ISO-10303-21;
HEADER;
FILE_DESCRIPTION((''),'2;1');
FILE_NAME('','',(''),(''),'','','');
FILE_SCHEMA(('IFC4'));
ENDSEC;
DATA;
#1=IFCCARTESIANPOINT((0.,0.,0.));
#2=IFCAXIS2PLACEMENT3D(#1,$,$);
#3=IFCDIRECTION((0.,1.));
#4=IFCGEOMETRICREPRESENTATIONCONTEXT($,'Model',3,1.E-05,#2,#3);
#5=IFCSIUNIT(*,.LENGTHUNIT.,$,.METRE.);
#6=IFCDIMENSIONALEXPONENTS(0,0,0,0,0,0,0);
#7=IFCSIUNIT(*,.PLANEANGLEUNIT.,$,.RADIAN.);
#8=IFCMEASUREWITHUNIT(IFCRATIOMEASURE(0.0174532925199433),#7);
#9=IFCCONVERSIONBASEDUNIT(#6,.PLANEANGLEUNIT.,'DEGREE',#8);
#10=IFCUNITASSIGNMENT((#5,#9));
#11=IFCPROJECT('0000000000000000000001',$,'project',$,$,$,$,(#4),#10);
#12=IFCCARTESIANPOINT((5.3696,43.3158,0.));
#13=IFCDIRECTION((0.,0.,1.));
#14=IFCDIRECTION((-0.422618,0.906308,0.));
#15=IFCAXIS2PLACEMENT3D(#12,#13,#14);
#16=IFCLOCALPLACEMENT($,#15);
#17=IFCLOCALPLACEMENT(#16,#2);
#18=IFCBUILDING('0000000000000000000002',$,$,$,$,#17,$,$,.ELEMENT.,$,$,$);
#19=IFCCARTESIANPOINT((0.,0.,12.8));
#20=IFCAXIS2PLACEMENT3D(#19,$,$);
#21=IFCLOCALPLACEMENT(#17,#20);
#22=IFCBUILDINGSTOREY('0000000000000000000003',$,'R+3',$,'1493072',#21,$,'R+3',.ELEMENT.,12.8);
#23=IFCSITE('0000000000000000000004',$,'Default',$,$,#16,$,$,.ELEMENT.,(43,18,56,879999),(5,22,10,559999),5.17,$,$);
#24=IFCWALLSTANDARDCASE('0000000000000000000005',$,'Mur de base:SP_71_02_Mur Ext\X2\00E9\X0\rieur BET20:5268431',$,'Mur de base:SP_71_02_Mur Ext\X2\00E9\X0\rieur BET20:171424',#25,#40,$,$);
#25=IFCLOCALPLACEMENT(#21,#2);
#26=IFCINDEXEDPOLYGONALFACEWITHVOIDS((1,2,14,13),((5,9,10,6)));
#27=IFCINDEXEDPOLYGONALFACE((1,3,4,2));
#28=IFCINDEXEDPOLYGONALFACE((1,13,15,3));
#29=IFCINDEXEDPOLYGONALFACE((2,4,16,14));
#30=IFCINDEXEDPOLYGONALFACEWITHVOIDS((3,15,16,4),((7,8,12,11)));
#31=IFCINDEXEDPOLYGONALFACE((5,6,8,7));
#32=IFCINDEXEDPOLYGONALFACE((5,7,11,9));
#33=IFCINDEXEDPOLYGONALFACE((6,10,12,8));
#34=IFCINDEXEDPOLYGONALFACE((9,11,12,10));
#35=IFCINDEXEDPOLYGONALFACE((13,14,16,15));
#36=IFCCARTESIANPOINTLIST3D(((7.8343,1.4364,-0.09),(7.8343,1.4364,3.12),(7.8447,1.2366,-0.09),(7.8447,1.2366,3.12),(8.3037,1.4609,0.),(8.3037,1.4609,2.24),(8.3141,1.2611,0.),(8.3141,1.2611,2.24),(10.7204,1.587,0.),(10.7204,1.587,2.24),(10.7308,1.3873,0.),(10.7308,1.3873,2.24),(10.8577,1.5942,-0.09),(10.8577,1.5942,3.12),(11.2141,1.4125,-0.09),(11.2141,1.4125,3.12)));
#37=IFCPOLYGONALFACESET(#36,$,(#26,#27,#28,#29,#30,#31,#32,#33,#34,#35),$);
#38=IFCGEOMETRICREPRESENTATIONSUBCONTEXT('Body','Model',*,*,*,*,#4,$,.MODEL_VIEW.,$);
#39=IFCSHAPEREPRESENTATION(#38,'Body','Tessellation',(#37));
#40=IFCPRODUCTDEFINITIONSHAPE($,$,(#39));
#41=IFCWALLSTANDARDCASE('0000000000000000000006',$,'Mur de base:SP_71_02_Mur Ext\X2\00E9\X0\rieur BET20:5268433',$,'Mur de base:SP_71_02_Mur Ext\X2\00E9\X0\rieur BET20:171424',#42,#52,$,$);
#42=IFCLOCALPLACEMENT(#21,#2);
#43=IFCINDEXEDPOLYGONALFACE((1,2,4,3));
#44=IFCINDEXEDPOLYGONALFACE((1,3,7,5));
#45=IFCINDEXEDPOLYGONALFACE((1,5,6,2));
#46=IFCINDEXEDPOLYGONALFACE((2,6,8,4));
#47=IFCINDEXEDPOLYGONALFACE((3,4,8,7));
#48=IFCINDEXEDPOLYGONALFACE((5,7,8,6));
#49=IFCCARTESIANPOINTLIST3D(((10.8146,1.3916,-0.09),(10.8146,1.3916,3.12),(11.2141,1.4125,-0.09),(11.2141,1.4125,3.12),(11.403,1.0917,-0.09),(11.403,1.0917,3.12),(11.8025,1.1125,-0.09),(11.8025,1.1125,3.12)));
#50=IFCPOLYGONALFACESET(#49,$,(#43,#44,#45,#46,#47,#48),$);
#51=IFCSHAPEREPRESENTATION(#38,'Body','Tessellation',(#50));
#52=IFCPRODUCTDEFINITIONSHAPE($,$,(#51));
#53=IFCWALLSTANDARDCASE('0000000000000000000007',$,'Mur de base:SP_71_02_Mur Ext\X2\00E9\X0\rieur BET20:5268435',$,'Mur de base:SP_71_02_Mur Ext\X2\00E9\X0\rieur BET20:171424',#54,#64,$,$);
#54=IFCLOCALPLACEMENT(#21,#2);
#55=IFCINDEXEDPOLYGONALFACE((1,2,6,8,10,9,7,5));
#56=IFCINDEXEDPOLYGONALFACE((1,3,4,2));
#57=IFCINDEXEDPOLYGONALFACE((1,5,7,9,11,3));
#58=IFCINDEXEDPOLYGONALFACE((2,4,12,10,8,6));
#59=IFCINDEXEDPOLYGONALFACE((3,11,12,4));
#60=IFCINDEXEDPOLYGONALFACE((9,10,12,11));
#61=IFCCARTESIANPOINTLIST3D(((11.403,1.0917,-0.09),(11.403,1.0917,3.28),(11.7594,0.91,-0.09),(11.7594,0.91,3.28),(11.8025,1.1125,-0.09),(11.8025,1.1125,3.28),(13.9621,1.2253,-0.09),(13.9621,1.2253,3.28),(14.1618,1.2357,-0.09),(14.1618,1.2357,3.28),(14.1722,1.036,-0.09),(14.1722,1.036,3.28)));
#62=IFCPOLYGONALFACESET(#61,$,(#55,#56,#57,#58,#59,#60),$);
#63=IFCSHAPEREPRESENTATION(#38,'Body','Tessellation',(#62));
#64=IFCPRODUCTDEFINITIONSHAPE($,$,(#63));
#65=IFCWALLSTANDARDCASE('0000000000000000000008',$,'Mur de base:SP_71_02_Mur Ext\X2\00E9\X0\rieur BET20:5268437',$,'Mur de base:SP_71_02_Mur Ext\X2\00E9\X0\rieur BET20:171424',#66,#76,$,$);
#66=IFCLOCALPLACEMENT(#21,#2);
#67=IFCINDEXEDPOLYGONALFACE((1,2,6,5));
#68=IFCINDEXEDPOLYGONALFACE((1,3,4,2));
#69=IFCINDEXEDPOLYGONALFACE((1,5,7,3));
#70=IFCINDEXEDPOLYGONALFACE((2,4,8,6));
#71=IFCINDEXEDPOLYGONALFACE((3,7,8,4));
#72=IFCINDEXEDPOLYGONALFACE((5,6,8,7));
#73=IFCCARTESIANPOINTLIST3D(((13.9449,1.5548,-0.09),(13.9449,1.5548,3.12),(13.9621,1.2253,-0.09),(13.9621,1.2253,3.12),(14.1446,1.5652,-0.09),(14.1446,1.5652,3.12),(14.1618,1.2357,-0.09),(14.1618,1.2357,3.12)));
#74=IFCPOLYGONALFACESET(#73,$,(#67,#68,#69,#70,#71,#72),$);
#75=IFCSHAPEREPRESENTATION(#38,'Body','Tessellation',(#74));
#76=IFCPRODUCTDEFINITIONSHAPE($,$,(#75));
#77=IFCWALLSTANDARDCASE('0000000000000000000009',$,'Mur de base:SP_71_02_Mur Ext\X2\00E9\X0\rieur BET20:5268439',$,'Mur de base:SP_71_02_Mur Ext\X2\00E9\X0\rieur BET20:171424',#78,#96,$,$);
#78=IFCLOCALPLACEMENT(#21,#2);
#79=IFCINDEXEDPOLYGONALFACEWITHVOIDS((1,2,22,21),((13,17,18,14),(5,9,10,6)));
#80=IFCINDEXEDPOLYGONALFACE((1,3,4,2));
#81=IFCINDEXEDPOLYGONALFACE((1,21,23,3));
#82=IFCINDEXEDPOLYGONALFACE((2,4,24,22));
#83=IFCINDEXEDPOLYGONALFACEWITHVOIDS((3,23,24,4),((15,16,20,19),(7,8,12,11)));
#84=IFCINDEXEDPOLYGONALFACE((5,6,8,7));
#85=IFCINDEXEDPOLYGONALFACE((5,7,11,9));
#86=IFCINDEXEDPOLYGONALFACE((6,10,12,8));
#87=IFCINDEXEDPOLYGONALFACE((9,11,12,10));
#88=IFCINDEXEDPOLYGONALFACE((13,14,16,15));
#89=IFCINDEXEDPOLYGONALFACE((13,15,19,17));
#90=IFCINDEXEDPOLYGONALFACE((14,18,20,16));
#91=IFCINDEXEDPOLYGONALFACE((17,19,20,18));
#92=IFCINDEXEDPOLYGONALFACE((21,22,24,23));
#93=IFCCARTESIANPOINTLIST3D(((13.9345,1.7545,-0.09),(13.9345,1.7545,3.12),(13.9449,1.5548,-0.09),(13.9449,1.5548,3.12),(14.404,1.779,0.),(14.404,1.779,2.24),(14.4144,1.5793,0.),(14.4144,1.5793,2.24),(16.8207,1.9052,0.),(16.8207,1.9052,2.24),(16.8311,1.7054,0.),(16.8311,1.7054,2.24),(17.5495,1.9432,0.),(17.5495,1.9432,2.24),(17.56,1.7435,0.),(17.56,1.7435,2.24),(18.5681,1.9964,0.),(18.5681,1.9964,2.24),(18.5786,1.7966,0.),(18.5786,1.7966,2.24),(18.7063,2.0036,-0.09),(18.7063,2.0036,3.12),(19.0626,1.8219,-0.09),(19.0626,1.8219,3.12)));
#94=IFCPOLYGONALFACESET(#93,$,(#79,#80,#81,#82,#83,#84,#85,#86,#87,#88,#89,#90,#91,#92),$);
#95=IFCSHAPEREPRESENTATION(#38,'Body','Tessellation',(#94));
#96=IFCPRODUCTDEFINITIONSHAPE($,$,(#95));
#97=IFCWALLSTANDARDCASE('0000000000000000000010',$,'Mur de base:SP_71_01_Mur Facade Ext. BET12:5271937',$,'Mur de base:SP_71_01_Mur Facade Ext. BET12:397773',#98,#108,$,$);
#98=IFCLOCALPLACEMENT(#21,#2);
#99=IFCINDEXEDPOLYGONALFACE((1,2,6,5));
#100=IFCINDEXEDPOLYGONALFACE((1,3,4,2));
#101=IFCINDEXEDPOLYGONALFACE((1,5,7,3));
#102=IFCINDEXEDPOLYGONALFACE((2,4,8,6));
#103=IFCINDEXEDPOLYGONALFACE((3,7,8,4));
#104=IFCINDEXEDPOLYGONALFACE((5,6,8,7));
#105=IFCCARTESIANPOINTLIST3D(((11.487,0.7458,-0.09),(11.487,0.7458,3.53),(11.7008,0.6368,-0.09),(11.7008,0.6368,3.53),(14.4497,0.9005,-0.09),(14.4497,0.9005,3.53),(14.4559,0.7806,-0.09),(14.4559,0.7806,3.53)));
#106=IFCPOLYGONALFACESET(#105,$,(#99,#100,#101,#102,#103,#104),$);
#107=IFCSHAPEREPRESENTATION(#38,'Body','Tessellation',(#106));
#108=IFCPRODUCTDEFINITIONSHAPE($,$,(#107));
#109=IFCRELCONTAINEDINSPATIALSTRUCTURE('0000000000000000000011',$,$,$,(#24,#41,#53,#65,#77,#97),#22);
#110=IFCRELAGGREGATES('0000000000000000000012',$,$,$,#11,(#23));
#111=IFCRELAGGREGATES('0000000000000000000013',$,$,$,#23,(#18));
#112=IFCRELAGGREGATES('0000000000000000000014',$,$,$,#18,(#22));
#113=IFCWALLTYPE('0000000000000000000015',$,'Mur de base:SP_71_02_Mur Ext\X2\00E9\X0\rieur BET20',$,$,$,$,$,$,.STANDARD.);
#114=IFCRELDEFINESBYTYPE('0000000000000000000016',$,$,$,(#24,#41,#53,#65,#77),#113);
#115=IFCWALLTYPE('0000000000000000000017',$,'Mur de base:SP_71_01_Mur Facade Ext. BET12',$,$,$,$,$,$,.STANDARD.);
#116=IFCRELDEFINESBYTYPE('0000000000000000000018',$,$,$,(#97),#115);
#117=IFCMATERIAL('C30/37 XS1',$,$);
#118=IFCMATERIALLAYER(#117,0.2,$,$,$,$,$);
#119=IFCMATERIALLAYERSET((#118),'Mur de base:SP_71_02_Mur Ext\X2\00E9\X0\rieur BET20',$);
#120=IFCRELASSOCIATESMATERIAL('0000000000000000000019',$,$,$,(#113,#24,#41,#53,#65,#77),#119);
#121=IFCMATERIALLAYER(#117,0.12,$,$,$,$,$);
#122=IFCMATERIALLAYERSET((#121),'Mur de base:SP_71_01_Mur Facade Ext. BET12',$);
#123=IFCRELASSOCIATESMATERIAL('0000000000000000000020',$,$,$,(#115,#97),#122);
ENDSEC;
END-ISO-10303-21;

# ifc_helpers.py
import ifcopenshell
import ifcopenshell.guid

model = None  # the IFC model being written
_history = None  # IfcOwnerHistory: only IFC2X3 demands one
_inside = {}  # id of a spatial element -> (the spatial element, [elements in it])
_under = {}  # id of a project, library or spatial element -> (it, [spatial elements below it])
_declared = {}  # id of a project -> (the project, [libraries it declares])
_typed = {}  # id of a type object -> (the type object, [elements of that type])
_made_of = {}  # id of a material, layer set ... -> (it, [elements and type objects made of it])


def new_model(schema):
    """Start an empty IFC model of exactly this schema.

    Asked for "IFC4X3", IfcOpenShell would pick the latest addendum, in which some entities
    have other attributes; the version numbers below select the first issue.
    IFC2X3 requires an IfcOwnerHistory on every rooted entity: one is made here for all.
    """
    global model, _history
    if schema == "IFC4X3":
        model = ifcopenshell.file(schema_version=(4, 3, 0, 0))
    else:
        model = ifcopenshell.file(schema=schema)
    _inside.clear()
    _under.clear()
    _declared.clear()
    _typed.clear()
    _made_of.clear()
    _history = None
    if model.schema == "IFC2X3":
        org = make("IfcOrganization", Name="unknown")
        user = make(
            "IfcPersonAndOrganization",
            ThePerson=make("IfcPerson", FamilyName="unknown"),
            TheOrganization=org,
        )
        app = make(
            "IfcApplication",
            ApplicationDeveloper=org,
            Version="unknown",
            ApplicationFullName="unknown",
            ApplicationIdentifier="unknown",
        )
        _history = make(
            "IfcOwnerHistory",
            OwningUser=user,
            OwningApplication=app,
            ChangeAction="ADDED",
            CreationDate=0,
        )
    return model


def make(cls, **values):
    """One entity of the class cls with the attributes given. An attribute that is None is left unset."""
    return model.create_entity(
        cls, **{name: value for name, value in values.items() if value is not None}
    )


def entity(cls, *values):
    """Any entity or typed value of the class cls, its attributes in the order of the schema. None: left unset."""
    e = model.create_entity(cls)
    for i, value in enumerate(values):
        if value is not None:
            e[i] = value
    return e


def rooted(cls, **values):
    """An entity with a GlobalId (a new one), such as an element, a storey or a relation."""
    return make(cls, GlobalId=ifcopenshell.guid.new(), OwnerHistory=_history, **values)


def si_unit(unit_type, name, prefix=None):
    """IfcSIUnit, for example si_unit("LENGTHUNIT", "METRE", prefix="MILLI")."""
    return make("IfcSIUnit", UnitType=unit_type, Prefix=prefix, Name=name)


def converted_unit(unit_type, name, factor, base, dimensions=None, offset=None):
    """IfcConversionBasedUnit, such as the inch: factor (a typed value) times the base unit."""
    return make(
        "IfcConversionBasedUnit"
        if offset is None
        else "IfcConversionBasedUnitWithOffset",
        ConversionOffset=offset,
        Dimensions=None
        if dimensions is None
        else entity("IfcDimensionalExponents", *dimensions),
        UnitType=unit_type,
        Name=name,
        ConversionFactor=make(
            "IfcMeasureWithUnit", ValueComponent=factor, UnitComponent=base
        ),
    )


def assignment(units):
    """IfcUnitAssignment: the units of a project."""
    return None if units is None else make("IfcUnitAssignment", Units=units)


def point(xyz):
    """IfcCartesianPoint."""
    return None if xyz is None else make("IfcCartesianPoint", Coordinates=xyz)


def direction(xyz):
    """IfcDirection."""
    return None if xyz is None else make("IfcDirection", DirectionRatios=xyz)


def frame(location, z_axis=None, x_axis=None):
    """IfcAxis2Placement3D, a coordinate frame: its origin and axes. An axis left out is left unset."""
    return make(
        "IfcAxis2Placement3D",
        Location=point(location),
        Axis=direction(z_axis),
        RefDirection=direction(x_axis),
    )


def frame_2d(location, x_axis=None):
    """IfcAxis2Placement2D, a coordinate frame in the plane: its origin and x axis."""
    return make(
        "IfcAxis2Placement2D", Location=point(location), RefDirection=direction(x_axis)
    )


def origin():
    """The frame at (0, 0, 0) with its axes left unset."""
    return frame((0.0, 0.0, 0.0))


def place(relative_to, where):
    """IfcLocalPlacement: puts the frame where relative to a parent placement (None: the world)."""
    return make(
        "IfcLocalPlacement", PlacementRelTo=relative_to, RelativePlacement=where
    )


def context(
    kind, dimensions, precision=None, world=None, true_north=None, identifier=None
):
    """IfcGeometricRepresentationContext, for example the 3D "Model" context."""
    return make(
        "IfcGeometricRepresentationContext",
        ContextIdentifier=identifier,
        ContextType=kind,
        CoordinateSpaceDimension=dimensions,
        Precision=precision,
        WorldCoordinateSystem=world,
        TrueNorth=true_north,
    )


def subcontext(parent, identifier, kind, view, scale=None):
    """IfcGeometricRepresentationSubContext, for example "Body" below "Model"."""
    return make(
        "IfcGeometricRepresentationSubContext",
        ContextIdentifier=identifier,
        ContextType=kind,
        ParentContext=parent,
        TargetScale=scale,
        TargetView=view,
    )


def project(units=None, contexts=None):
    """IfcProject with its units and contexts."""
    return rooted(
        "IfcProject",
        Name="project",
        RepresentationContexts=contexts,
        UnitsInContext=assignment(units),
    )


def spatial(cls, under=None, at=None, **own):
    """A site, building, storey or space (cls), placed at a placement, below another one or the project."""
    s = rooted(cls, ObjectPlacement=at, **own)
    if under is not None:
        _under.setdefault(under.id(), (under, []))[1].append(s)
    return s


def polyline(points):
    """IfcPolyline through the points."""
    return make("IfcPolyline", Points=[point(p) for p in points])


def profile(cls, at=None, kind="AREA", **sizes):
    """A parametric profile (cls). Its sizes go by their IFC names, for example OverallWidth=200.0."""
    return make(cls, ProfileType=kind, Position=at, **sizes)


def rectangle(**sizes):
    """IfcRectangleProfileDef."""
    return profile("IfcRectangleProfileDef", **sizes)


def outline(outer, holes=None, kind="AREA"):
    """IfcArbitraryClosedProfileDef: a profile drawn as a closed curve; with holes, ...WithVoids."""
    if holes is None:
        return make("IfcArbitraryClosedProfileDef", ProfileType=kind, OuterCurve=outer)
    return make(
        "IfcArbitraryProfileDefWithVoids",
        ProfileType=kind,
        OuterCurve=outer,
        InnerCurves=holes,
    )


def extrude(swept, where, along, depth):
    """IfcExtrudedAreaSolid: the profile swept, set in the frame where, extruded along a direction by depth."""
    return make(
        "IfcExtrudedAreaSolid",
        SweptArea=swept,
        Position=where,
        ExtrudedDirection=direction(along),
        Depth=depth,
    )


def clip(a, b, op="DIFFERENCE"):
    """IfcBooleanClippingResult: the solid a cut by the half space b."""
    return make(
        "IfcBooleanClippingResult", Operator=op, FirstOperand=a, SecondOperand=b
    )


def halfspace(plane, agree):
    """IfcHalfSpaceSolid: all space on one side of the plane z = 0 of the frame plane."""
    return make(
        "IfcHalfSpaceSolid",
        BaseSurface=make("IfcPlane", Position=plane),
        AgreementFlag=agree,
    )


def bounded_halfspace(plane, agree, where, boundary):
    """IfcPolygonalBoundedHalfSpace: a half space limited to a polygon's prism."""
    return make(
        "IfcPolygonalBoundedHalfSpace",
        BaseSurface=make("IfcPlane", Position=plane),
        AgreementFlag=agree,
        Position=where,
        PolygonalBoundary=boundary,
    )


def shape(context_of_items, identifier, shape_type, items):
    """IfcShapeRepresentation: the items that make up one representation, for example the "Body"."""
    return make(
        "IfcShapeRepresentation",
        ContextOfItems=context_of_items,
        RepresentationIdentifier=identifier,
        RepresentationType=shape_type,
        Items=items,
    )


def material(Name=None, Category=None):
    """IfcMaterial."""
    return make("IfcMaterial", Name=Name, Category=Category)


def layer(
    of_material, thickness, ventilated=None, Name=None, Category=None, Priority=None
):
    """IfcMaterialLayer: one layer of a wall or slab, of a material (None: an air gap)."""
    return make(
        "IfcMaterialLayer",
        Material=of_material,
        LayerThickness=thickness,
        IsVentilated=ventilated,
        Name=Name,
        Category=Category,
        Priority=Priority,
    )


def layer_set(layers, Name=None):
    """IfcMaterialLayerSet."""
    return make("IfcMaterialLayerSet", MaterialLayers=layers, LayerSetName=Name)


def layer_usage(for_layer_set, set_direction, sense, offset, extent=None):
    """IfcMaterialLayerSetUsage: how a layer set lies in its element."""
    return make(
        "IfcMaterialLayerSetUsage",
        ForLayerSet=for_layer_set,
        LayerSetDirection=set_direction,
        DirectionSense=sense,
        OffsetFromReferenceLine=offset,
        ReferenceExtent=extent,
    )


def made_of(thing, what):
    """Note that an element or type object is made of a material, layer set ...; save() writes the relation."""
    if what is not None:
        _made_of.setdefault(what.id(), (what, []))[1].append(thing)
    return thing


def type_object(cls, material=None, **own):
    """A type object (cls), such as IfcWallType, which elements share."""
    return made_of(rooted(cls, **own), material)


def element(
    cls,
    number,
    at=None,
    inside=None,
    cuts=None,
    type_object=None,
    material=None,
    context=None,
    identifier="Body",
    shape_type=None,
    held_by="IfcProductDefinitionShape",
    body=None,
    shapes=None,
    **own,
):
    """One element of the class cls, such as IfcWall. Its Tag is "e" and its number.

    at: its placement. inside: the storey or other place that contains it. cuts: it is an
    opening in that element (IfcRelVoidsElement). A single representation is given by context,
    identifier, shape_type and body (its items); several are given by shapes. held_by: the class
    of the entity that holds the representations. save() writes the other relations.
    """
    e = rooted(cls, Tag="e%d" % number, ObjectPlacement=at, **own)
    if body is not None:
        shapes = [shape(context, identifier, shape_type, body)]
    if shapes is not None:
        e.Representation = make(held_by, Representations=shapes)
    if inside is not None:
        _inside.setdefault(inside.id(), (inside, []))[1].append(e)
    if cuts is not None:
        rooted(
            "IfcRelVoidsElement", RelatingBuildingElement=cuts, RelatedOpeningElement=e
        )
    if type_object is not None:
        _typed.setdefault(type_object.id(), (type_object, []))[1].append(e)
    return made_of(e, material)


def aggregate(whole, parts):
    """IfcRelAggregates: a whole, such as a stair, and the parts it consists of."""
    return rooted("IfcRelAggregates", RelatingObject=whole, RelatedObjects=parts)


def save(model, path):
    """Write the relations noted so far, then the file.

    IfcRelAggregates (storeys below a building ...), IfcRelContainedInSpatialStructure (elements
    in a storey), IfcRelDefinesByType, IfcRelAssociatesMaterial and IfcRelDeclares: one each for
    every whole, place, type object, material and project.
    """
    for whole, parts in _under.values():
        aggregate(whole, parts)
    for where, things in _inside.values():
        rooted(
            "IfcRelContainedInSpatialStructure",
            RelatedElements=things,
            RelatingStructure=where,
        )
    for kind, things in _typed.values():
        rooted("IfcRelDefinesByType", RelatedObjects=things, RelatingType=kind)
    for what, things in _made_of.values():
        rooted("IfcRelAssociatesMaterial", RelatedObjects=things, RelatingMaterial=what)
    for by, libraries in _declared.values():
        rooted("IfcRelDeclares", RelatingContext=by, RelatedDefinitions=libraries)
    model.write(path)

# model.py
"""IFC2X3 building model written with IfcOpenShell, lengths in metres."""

from ifc_helpers import new_model, entity, si_unit, converted_unit, direction, frame, frame_2d, origin, place, context, subcontext, project, spatial, polyline, rectangle, outline, extrude, clip, halfspace, bounded_halfspace, material, layer, layer_set, layer_usage, type_object, element, save


model = new_model("IFC2X3")

# Units and contexts
model_context = context("Model", 3, precision=1e-05, world=origin(), true_north=direction((0.0, 1.0)))
body_context = subcontext(model_context, "Body", "Model", "MODEL_VIEW")
ifc_project = project(units=[si_unit("LENGTHUNIT", "METRE"), converted_unit("PLANEANGLEUNIT", "DEGREE", entity("IfcRatioMeasure", 0.0174532925199433), si_unit("PLANEANGLEUNIT", "RADIAN"), dimensions=[0, 0, 0, 0, 0, 0, 0])], contexts=[model_context])

# Site, building, storey
site_placement = place(None, frame((5.3696, 43.3158, 0.0), z_axis=(0.0, 0.0, 1.0), x_axis=(-0.422618, 0.906308, 0.0)))
site = spatial("IfcSite", under=ifc_project, at=site_placement, Name="Default", CompositionType="ELEMENT", RefLatitude=(43, 18, 56, 879999), RefLongitude=(5, 22, 10, 559999), RefElevation=5.17)
building_placement = place(site_placement, origin())
building = spatial("IfcBuilding", under=site, at=building_placement, CompositionType="ELEMENT")
storey_placement = place(building_placement, frame((0.0, 0.0, 12.8)))
storey = spatial("IfcBuildingStorey", under=building, at=storey_placement, Name="R+3", ObjectType="1493072", LongName="R+3", CompositionType="ELEMENT", Elevation=12.8)

# Shared definitions
ifc_material_1 = material(Name="C30/37 XS1")

# Wall, opening
ifc_layer_1 = layer(ifc_material_1, 0.2)
ifc_layer_set_1 = layer_set([ifc_layer_1], Name="Mur de base:SP_71_02_Mur Extérieur BET20")
ifc_layer_usage_1 = layer_usage(ifc_layer_set_1, "AXIS2", "NEGATIVE", 0.1)
wall_type_1 = type_object("IfcWallType", Name="Mur de base:SP_71_02_Mur Extérieur BET20", PredefinedType="STANDARD", material=ifc_layer_set_1)
wall_1_placement = place(storey_placement, frame((7.8395, 1.3365, -0.09), z_axis=(0.0, 0.0, 1.0), x_axis=(0.998641, 0.05212, 0.0)))
wall_1 = element("IfcWallStandardCase", 1, at=wall_1_placement, inside=storey, type_object=wall_type_1, material=ifc_layer_usage_1, Name="Mur de base:SP_71_02_Mur Extérieur BET20:5268431", ObjectType="Mur de base:SP_71_02_Mur Extérieur BET20:171424", context=body_context, shape_type="Clipping", body=[
    clip(extrude(outline(polyline([(3.374, -0.1), (3.0276, 0.1), (0.0, 0.1), (0.0, -0.1), (0.2, -0.1), (2.974, -0.1), (3.374, -0.1)])), origin(), (0.0, 0.0, 1.0), 3.21), bounded_halfspace(frame((0.0, -0.1, 3.21), z_axis=(0.0, 0.0, -1.0), x_axis=(0.998641, -0.05212, 0.0)), True, frame((0.0, -0.1, 3.21), z_axis=(0.0, 0.0, -1.0), x_axis=(0.998641, -0.05212, 0.0)), polyline([(0.0, 0.0), (-0.0104, -0.1997), (3.013, -0.3575), (3.3694, -0.1759), (2.9699, -0.155), (0.1997, -0.0104), (0.0, 0.0)]))),
])
opening_1_placement = place(wall_1_placement, origin())
element("IfcOpeningElement", 2, at=opening_1_placement, cuts=wall_1, ObjectType="Opening", context=body_context, shape_type="SweptSolid", body=[
    extrude(rectangle(XDim=2.24, YDim=2.42, at=frame_2d((0.0, 0.0), x_axis=(1.0, 0.0))), frame((1.68, -1.424, 1.21), z_axis=(0.0, 1.0, 0.0), x_axis=(0.0, 0.0, -1.0)), (0.0, 0.0, 1.0), 3.048),
])

# Walls
ifc_layer_usage_2 = layer_usage(ifc_layer_set_1, "AXIS2", "NEGATIVE", 0.1)
wall_2_placement = place(storey_placement, frame((11.757, 1.0235, -0.09), z_axis=(0.0, 0.0, 1.0), x_axis=(-0.890908, 0.454183, 0.0)))
element("IfcWallStandardCase", 3, at=wall_2_placement, inside=storey, type_object=wall_type_1, material=ifc_layer_usage_2, Name="Mur de base:SP_71_02_Mur Extérieur BET20:5268433", ObjectType="Mur de base:SP_71_02_Mur Extérieur BET20:171424", context=body_context, shape_type="Clipping", body=[
    clip(extrude(outline(polyline([(0.6604, -0.1), (1.0068, 0.1), (0.3464, 0.1), (0.0, -0.1), (0.6604, -0.1)])), origin(), (0.0, 0.0, 1.0), 3.21), bounded_halfspace(frame((0.0, -0.1, 3.21), z_axis=(0.0, 0.0, -1.0), x_axis=(-0.890908, -0.454183, 0.0)), True, frame((0.0, -0.1, 3.21), z_axis=(0.0, 0.0, -1.0), x_axis=(-0.890908, -0.454183, 0.0)), polyline([(0.0, 0.0), (-0.3995, 0.0208), (-0.9878, -0.2791), (-0.5884, -0.2999), (0.0, 0.0)]))),
])
ifc_layer_usage_3 = layer_usage(ifc_layer_set_1, "AXIS2", "NEGATIVE", 0.1)
wall_3_placement = place(storey_placement, frame((14.167, 1.1358, -0.09), z_axis=(0.0, 0.0, 1.0), x_axis=(-0.998641, -0.05212, 0.0)))
element("IfcWallStandardCase", 4, at=wall_3_placement, inside=storey, type_object=wall_type_1, material=ifc_layer_usage_3, Name="Mur de base:SP_71_02_Mur Extérieur BET20:5268435", ObjectType="Mur de base:SP_71_02_Mur Extérieur BET20:171424", context=body_context, shape_type="SweptSolid", body=[
    extrude(outline(polyline([(2.7626, -0.1), (2.4161, 0.1), (0.0, 0.1), (0.0, -0.1), (0.2, -0.1), (2.3626, -0.1), (2.7626, -0.1)])), origin(), (0.0, 0.0, 1.0), 3.37),
])
ifc_layer_usage_4 = layer_usage(ifc_layer_set_1, "AXIS2", "NEGATIVE", 0.1)
wall_4_placement = place(storey_placement, frame((14.0447, 1.56, -0.09), z_axis=(0.0, 0.0, 1.0), x_axis=(0.05212, -0.998641, 0.0)))
element("IfcWallStandardCase", 5, at=wall_4_placement, inside=storey, type_object=wall_type_1, material=ifc_layer_usage_4, Name="Mur de base:SP_71_02_Mur Extérieur BET20:5268437", ObjectType="Mur de base:SP_71_02_Mur Extérieur BET20:171424", context=body_context, shape_type="Clipping", body=[
    clip(extrude(rectangle(XDim=0.33, YDim=0.2, at=frame_2d((0.165, 0.0), x_axis=(-1.0, 0.0))), origin(), (0.0, 0.0, 1.0), 3.21), bounded_halfspace(frame((0.0, -0.1, 3.21), z_axis=(0.0, 0.0, -1.0), x_axis=(0.05212, 0.998641, 0.0)), True, frame((0.0, -0.1, 3.21), z_axis=(0.0, 0.0, -1.0), x_axis=(0.05212, 0.998641, 0.0)), polyline([(0.0, 0.0), (0.1997, -0.0104), (0.2169, 0.3191), (0.0172, 0.3296), (0.0, 0.0)]))),
])

# Wall, openings
ifc_layer_usage_5 = layer_usage(ifc_layer_set_1, "AXIS2", "NEGATIVE", 0.1)
wall_5_placement = place(storey_placement, frame((13.9397, 1.6547, -0.09), z_axis=(0.0, 0.0, 1.0), x_axis=(0.998641, 0.05212, 0.0)))
wall_5 = element("IfcWallStandardCase", 6, at=wall_5_placement, inside=storey, type_object=wall_type_1, material=ifc_layer_usage_5, Name="Mur de base:SP_71_02_Mur Extérieur BET20:5268439", ObjectType="Mur de base:SP_71_02_Mur Extérieur BET20:171424", context=body_context, shape_type="Clipping", body=[
    clip(extrude(outline(polyline([(5.1247, -0.1), (4.7783, 0.1), (0.0, 0.1), (0.0, -0.1), (0.2, -0.1), (4.7247, -0.1), (5.1247, -0.1)])), origin(), (0.0, 0.0, 1.0), 3.21), bounded_halfspace(frame((0.0, -0.1, 3.21), z_axis=(0.0, 0.0, -1.0), x_axis=(0.998641, -0.05212, 0.0)), True, frame((0.0, -0.1, 3.21), z_axis=(0.0, 0.0, -1.0), x_axis=(0.998641, -0.05212, 0.0)), polyline([(0.0, 0.0), (-0.0104, -0.1997), (4.7614, -0.4488), (5.1177, -0.2671), (4.7183, -0.2463), (0.1997, -0.0104), (0.0, 0.0)]))),
])
opening_2_placement = place(wall_5_placement, origin())
element("IfcOpeningElement", 7, at=opening_2_placement, cuts=wall_5, ObjectType="Opening", context=body_context, shape_type="SweptSolid", body=[
    extrude(rectangle(XDim=2.24, YDim=2.42, at=frame_2d((0.0, 0.0), x_axis=(1.0, 0.0))), frame((1.6802, -1.424, 1.21), z_axis=(0.0, 1.0, 0.0), x_axis=(0.0, 0.0, -1.0)), (0.0, 0.0, 1.0), 3.048),
])
opening_3_placement = place(wall_5_placement, origin())
element("IfcOpeningElement", 8, at=opening_3_placement, cuts=wall_5, ObjectType="Opening", context=body_context, shape_type="SweptSolid", body=[
    extrude(rectangle(XDim=2.24, YDim=1.02, at=frame_2d((0.0, 0.0), x_axis=(1.0, 0.0))), frame((4.13, -1.424, 1.21), z_axis=(0.0, 1.0, 0.0), x_axis=(0.0, 0.0, -1.0)), (0.0, 0.0, 1.0), 3.048),
])

# Shared definitions
ifc_layer_2 = layer(ifc_material_1, 0.12)
ifc_layer_set_2 = layer_set([ifc_layer_2], Name="Mur de base:SP_71_01_Mur Facade Ext. BET12")
wall_type_2 = type_object("IfcWallType", Name="Mur de base:SP_71_01_Mur Facade Ext. BET12", PredefinedType="STANDARD", material=ifc_layer_set_2)

# Wall
ifc_layer_usage_6 = layer_usage(ifc_layer_set_2, "AXIS2", "NEGATIVE", 0.06)
wall_6_placement = place(storey_placement, frame((14.4528, 0.8405, -0.09), z_axis=(0.0, 0.0, 1.0), x_axis=(-0.998641, -0.05212, 0.0)))
element("IfcWallStandardCase", 9, at=wall_6_placement, inside=storey, type_object=wall_type_2, material=ifc_layer_usage_6, Name="Mur de base:SP_71_01_Mur Facade Ext. BET12:5271937", ObjectType="Mur de base:SP_71_01_Mur Facade Ext. BET12:397773", context=body_context, shape_type="Clipping", body=[
    clip(extrude(outline(polyline([(2.9667, -0.06), (2.7589, 0.06), (2.7484, 0.06), (0.0, 0.06), (0.0, -0.06), (0.12, -0.06), (2.7267, -0.06), (2.9562, -0.06), (2.9667, -0.06)])), origin(), (0.0, 0.0, 1.0), 3.62), halfspace(frame((0.0, 0.0, -0.09)), True)),
])

save(model, "model.ifc")
